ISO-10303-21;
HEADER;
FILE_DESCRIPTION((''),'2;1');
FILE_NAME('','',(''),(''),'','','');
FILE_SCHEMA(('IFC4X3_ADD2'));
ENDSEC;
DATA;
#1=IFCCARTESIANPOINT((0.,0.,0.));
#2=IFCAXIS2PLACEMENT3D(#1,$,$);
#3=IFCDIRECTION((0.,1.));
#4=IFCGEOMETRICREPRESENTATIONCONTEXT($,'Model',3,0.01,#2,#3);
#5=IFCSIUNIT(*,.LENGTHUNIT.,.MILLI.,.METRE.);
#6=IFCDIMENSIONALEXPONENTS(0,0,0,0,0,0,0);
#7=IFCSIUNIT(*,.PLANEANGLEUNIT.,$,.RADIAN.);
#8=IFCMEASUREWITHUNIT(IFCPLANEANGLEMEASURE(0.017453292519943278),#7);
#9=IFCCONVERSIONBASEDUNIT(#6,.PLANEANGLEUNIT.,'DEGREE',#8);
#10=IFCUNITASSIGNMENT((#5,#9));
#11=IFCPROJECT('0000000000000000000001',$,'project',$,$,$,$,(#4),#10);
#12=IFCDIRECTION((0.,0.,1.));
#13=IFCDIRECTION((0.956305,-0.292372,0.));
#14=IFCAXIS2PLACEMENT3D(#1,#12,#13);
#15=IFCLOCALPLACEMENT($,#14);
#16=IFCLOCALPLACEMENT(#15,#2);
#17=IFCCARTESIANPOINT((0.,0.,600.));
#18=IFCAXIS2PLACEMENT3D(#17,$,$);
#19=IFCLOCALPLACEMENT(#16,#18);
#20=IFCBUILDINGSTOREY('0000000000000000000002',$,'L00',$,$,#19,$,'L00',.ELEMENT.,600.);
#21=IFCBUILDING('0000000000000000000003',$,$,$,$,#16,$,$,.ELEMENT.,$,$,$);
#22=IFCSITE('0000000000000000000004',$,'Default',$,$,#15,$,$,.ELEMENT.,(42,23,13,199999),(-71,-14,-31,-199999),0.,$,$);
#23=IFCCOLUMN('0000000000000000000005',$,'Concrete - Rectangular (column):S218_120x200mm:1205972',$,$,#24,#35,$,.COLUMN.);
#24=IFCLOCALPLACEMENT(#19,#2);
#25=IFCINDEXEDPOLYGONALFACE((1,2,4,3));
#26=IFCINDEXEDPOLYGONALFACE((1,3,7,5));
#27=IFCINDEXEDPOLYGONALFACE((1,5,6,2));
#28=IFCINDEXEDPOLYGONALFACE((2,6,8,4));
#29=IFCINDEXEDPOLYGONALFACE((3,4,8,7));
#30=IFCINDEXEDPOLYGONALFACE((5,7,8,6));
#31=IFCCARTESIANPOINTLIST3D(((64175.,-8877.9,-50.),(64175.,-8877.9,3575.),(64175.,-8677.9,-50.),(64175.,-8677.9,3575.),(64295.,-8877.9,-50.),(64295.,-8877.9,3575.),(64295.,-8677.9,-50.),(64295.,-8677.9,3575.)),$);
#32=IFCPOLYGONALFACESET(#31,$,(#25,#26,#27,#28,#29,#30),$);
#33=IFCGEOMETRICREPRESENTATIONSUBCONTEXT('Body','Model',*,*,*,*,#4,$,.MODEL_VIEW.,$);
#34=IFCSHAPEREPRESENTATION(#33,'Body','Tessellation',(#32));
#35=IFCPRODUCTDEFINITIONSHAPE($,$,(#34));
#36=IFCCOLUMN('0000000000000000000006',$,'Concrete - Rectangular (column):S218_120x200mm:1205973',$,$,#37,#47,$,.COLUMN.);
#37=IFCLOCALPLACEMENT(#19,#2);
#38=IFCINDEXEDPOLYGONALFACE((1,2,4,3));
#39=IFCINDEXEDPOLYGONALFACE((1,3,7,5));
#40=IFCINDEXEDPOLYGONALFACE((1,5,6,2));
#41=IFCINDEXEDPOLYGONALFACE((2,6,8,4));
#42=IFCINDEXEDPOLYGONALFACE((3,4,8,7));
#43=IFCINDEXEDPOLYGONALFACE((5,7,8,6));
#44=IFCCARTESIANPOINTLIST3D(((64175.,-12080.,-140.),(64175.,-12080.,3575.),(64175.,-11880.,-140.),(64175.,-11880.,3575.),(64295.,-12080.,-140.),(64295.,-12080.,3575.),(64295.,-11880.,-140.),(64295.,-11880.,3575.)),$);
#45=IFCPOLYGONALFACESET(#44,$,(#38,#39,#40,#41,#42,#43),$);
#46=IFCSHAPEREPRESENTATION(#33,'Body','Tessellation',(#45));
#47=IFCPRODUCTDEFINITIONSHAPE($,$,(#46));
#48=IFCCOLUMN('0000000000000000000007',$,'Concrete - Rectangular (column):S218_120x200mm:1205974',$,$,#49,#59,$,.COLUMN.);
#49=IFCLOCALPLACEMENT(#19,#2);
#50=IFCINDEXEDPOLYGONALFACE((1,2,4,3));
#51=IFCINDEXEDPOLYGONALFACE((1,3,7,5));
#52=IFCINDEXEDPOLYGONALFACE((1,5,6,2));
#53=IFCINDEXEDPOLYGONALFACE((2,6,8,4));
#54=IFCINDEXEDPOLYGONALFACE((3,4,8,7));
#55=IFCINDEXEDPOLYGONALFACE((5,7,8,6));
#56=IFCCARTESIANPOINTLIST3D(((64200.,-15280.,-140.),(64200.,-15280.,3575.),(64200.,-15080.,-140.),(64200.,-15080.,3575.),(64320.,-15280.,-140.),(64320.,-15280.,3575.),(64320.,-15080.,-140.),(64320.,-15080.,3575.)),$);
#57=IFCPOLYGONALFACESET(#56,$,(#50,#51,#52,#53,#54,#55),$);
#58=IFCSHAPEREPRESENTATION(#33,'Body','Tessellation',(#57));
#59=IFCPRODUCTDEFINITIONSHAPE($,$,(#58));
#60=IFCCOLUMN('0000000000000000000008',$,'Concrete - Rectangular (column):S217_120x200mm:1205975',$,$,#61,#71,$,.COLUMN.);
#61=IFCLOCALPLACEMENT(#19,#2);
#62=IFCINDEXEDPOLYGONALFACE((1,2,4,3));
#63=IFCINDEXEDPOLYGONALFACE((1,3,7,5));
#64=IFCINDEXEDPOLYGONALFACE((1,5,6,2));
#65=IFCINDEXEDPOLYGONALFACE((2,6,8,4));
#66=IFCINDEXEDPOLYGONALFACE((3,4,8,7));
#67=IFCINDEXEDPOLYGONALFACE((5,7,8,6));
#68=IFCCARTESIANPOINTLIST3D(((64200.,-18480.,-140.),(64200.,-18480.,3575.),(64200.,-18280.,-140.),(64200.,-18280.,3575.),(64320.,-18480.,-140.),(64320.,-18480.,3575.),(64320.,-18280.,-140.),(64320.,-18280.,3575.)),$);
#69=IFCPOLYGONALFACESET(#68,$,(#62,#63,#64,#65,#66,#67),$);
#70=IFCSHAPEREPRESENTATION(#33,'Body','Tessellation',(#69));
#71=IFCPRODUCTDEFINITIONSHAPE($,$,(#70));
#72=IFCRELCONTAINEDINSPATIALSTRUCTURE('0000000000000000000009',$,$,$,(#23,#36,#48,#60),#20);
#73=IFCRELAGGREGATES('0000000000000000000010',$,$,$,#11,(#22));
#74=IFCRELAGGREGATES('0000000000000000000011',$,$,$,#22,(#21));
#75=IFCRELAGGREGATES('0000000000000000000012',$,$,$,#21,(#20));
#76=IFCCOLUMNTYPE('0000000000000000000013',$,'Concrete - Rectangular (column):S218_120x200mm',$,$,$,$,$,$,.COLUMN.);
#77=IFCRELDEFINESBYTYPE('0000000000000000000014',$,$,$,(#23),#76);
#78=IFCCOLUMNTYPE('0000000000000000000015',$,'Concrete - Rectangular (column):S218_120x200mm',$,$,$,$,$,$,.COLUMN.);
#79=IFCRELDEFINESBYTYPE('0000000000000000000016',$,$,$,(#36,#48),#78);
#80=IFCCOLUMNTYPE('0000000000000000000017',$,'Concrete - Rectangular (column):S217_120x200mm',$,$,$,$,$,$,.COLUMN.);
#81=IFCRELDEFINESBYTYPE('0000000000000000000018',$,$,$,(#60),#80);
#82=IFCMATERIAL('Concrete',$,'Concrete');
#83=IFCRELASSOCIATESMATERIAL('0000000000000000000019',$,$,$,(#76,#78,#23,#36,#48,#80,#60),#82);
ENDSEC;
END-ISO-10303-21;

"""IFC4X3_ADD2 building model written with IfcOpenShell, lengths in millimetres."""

from ifc_helpers import new_model, entity, si_unit, converted_unit, direction, frame, frame_2d, origin, origin_2d_with_axis, place, context, subcontext, project, spatial, rectangle, extrude, source, transform, mapped, material, material_profile, profile_set, profile_usage, type_object, type_shapes, element, save


model = new_model("IFC4X3_ADD2")

# Units and contexts
model_context = context("Model", 3, precision=0.01, world=origin(), true_north=direction((0.0, 1.0)))
body_context = subcontext(model_context, "Body", "Model", "MODEL_VIEW")
ifc_project = project(units=[si_unit("LENGTHUNIT", "METRE", prefix="MILLI"), converted_unit("PLANEANGLEUNIT", "DEGREE", entity("IfcPlaneAngleMeasure", 0.017453292519943278), si_unit("PLANEANGLEUNIT", "RADIAN"), dimensions=[0, 0, 0, 0, 0, 0, 0])], contexts=[model_context])

# Site, building, storey
site_placement = place(None, frame((0.0, 0.0, 0.0), z_axis=(0.0, 0.0, 1.0), x_axis=(0.956305, -0.292372, 0.0)))
site = spatial("IfcSite", under=ifc_project, at=site_placement, Name="Default", CompositionType="ELEMENT", RefLatitude=(42, 23, 13, 199999), RefLongitude=(-71, -14, -31, -199999), RefElevation=0.0)
building_placement = place(site_placement, origin())
building = spatial("IfcBuilding", under=site, at=building_placement, CompositionType="ELEMENT")
storey_placement = place(building_placement, frame((0.0, 0.0, 600.0)))
storey = spatial("IfcBuildingStorey", under=building, at=storey_placement, Name="L00", LongName="L00", CompositionType="ELEMENT", Elevation=600.0)

# Columns
ifc_material_1 = material(Name="Concrete", Category="Concrete")
ifc_material_profile_1 = material_profile(ifc_material_1, rectangle(XDim=120.0, YDim=200.0, at=frame_2d((0.0, 0.0), x_axis=(1.0, 0.0))), Name="S218_120x200mm")
ifc_profile_set_1 = profile_set([ifc_material_profile_1], Name="S218_120x200mm")
ifc_profile_usage_1 = profile_usage(ifc_profile_set_1)
column_type_1 = type_object("IfcColumnType", Name="Concrete - Rectangular (column):S218_120x200mm", PredefinedType="COLUMN", material=ifc_profile_set_1)
shared_shape_1 = source(origin(), body_context, "Body", "SweptSolid", [
    extrude(rectangle(XDim=120.0, YDim=200.0, at=origin_2d_with_axis()), frame((0.0, 0.0, 550.0), z_axis=(0.0, 0.0, 1.0), x_axis=(-1.0, 0.0, 0.0)), (0.0, 0.0, 1.0), 3625.0),
])
type_shapes(column_type_1, [shared_shape_1])
column_1_placement = place(storey_placement, frame((64235.0, -8777.9, -600.0)))
element("IfcColumn", 1, at=column_1_placement, inside=storey, type_object=column_type_1, material=ifc_profile_usage_1, Name="Concrete - Rectangular (column):S218_120x200mm:1205972", PredefinedType="COLUMN", context=body_context, shape_type="MappedRepresentation", body=[
    mapped(shared_shape_1, transform((0.0, 0.0, 0.0), scale=1.0)),
])
column_type_2 = type_object("IfcColumnType", Name="Concrete - Rectangular (column):S218_120x200mm", PredefinedType="COLUMN", material=ifc_profile_set_1)
shared_shape_2 = source(origin(), body_context, "Body", "SweptSolid", [
    extrude(rectangle(XDim=120.0, YDim=200.0, at=origin_2d_with_axis()), frame((0.0, 0.0, 460.0), z_axis=(0.0, 0.0, 1.0), x_axis=(-1.0, 0.0, 0.0)), (0.0, 0.0, 1.0), 3715.0),
])
type_shapes(column_type_2, [shared_shape_2])
for number, where, name in (
    (2, (64235.0, -11980.0, -600.0), "Concrete - Rectangular (column):S218_120x200mm:1205973"),
    (3, (64260.0, -15180.0, -600.0), "Concrete - Rectangular (column):S218_120x200mm:1205974"),
):
    element("IfcColumn", number, at=place(storey_placement, frame(where)), inside=storey, type_object=column_type_2, material=ifc_profile_usage_1, Name=name, PredefinedType="COLUMN", context=body_context, shape_type="MappedRepresentation", body=[
        mapped(shared_shape_2, transform((0.0, 0.0, 0.0), scale=1.0)),
    ])
ifc_material_profile_2 = material_profile(ifc_material_1, rectangle(XDim=120.0, YDim=200.0, at=origin_2d_with_axis()), Name="S217_120x200mm")
ifc_profile_set_2 = profile_set([ifc_material_profile_2], Name="S217_120x200mm")
ifc_profile_usage_2 = profile_usage(ifc_profile_set_2)
column_type_3 = type_object("IfcColumnType", Name="Concrete - Rectangular (column):S217_120x200mm", PredefinedType="COLUMN", material=ifc_profile_set_2)
shared_shape_3 = source(origin(), body_context, "Body", "SweptSolid", [
    extrude(rectangle(XDim=120.0, YDim=200.0, at=origin_2d_with_axis()), frame((0.0, 0.0, 460.0), z_axis=(0.0, 0.0, 1.0), x_axis=(-1.0, 0.0, 0.0)), (0.0, 0.0, 1.0), 3715.0),
])
type_shapes(column_type_3, [shared_shape_3])
column_2_placement = place(storey_placement, frame((64260.0, -18380.0, -600.0)))
element("IfcColumn", 4, at=column_2_placement, inside=storey, type_object=column_type_3, material=ifc_profile_usage_2, Name="Concrete - Rectangular (column):S217_120x200mm:1205975", PredefinedType="COLUMN", context=body_context, shape_type="MappedRepresentation", body=[
    mapped(shared_shape_3, transform((0.0, 0.0, 0.0), scale=1.0)),
])

save(model, "model.ifc")
